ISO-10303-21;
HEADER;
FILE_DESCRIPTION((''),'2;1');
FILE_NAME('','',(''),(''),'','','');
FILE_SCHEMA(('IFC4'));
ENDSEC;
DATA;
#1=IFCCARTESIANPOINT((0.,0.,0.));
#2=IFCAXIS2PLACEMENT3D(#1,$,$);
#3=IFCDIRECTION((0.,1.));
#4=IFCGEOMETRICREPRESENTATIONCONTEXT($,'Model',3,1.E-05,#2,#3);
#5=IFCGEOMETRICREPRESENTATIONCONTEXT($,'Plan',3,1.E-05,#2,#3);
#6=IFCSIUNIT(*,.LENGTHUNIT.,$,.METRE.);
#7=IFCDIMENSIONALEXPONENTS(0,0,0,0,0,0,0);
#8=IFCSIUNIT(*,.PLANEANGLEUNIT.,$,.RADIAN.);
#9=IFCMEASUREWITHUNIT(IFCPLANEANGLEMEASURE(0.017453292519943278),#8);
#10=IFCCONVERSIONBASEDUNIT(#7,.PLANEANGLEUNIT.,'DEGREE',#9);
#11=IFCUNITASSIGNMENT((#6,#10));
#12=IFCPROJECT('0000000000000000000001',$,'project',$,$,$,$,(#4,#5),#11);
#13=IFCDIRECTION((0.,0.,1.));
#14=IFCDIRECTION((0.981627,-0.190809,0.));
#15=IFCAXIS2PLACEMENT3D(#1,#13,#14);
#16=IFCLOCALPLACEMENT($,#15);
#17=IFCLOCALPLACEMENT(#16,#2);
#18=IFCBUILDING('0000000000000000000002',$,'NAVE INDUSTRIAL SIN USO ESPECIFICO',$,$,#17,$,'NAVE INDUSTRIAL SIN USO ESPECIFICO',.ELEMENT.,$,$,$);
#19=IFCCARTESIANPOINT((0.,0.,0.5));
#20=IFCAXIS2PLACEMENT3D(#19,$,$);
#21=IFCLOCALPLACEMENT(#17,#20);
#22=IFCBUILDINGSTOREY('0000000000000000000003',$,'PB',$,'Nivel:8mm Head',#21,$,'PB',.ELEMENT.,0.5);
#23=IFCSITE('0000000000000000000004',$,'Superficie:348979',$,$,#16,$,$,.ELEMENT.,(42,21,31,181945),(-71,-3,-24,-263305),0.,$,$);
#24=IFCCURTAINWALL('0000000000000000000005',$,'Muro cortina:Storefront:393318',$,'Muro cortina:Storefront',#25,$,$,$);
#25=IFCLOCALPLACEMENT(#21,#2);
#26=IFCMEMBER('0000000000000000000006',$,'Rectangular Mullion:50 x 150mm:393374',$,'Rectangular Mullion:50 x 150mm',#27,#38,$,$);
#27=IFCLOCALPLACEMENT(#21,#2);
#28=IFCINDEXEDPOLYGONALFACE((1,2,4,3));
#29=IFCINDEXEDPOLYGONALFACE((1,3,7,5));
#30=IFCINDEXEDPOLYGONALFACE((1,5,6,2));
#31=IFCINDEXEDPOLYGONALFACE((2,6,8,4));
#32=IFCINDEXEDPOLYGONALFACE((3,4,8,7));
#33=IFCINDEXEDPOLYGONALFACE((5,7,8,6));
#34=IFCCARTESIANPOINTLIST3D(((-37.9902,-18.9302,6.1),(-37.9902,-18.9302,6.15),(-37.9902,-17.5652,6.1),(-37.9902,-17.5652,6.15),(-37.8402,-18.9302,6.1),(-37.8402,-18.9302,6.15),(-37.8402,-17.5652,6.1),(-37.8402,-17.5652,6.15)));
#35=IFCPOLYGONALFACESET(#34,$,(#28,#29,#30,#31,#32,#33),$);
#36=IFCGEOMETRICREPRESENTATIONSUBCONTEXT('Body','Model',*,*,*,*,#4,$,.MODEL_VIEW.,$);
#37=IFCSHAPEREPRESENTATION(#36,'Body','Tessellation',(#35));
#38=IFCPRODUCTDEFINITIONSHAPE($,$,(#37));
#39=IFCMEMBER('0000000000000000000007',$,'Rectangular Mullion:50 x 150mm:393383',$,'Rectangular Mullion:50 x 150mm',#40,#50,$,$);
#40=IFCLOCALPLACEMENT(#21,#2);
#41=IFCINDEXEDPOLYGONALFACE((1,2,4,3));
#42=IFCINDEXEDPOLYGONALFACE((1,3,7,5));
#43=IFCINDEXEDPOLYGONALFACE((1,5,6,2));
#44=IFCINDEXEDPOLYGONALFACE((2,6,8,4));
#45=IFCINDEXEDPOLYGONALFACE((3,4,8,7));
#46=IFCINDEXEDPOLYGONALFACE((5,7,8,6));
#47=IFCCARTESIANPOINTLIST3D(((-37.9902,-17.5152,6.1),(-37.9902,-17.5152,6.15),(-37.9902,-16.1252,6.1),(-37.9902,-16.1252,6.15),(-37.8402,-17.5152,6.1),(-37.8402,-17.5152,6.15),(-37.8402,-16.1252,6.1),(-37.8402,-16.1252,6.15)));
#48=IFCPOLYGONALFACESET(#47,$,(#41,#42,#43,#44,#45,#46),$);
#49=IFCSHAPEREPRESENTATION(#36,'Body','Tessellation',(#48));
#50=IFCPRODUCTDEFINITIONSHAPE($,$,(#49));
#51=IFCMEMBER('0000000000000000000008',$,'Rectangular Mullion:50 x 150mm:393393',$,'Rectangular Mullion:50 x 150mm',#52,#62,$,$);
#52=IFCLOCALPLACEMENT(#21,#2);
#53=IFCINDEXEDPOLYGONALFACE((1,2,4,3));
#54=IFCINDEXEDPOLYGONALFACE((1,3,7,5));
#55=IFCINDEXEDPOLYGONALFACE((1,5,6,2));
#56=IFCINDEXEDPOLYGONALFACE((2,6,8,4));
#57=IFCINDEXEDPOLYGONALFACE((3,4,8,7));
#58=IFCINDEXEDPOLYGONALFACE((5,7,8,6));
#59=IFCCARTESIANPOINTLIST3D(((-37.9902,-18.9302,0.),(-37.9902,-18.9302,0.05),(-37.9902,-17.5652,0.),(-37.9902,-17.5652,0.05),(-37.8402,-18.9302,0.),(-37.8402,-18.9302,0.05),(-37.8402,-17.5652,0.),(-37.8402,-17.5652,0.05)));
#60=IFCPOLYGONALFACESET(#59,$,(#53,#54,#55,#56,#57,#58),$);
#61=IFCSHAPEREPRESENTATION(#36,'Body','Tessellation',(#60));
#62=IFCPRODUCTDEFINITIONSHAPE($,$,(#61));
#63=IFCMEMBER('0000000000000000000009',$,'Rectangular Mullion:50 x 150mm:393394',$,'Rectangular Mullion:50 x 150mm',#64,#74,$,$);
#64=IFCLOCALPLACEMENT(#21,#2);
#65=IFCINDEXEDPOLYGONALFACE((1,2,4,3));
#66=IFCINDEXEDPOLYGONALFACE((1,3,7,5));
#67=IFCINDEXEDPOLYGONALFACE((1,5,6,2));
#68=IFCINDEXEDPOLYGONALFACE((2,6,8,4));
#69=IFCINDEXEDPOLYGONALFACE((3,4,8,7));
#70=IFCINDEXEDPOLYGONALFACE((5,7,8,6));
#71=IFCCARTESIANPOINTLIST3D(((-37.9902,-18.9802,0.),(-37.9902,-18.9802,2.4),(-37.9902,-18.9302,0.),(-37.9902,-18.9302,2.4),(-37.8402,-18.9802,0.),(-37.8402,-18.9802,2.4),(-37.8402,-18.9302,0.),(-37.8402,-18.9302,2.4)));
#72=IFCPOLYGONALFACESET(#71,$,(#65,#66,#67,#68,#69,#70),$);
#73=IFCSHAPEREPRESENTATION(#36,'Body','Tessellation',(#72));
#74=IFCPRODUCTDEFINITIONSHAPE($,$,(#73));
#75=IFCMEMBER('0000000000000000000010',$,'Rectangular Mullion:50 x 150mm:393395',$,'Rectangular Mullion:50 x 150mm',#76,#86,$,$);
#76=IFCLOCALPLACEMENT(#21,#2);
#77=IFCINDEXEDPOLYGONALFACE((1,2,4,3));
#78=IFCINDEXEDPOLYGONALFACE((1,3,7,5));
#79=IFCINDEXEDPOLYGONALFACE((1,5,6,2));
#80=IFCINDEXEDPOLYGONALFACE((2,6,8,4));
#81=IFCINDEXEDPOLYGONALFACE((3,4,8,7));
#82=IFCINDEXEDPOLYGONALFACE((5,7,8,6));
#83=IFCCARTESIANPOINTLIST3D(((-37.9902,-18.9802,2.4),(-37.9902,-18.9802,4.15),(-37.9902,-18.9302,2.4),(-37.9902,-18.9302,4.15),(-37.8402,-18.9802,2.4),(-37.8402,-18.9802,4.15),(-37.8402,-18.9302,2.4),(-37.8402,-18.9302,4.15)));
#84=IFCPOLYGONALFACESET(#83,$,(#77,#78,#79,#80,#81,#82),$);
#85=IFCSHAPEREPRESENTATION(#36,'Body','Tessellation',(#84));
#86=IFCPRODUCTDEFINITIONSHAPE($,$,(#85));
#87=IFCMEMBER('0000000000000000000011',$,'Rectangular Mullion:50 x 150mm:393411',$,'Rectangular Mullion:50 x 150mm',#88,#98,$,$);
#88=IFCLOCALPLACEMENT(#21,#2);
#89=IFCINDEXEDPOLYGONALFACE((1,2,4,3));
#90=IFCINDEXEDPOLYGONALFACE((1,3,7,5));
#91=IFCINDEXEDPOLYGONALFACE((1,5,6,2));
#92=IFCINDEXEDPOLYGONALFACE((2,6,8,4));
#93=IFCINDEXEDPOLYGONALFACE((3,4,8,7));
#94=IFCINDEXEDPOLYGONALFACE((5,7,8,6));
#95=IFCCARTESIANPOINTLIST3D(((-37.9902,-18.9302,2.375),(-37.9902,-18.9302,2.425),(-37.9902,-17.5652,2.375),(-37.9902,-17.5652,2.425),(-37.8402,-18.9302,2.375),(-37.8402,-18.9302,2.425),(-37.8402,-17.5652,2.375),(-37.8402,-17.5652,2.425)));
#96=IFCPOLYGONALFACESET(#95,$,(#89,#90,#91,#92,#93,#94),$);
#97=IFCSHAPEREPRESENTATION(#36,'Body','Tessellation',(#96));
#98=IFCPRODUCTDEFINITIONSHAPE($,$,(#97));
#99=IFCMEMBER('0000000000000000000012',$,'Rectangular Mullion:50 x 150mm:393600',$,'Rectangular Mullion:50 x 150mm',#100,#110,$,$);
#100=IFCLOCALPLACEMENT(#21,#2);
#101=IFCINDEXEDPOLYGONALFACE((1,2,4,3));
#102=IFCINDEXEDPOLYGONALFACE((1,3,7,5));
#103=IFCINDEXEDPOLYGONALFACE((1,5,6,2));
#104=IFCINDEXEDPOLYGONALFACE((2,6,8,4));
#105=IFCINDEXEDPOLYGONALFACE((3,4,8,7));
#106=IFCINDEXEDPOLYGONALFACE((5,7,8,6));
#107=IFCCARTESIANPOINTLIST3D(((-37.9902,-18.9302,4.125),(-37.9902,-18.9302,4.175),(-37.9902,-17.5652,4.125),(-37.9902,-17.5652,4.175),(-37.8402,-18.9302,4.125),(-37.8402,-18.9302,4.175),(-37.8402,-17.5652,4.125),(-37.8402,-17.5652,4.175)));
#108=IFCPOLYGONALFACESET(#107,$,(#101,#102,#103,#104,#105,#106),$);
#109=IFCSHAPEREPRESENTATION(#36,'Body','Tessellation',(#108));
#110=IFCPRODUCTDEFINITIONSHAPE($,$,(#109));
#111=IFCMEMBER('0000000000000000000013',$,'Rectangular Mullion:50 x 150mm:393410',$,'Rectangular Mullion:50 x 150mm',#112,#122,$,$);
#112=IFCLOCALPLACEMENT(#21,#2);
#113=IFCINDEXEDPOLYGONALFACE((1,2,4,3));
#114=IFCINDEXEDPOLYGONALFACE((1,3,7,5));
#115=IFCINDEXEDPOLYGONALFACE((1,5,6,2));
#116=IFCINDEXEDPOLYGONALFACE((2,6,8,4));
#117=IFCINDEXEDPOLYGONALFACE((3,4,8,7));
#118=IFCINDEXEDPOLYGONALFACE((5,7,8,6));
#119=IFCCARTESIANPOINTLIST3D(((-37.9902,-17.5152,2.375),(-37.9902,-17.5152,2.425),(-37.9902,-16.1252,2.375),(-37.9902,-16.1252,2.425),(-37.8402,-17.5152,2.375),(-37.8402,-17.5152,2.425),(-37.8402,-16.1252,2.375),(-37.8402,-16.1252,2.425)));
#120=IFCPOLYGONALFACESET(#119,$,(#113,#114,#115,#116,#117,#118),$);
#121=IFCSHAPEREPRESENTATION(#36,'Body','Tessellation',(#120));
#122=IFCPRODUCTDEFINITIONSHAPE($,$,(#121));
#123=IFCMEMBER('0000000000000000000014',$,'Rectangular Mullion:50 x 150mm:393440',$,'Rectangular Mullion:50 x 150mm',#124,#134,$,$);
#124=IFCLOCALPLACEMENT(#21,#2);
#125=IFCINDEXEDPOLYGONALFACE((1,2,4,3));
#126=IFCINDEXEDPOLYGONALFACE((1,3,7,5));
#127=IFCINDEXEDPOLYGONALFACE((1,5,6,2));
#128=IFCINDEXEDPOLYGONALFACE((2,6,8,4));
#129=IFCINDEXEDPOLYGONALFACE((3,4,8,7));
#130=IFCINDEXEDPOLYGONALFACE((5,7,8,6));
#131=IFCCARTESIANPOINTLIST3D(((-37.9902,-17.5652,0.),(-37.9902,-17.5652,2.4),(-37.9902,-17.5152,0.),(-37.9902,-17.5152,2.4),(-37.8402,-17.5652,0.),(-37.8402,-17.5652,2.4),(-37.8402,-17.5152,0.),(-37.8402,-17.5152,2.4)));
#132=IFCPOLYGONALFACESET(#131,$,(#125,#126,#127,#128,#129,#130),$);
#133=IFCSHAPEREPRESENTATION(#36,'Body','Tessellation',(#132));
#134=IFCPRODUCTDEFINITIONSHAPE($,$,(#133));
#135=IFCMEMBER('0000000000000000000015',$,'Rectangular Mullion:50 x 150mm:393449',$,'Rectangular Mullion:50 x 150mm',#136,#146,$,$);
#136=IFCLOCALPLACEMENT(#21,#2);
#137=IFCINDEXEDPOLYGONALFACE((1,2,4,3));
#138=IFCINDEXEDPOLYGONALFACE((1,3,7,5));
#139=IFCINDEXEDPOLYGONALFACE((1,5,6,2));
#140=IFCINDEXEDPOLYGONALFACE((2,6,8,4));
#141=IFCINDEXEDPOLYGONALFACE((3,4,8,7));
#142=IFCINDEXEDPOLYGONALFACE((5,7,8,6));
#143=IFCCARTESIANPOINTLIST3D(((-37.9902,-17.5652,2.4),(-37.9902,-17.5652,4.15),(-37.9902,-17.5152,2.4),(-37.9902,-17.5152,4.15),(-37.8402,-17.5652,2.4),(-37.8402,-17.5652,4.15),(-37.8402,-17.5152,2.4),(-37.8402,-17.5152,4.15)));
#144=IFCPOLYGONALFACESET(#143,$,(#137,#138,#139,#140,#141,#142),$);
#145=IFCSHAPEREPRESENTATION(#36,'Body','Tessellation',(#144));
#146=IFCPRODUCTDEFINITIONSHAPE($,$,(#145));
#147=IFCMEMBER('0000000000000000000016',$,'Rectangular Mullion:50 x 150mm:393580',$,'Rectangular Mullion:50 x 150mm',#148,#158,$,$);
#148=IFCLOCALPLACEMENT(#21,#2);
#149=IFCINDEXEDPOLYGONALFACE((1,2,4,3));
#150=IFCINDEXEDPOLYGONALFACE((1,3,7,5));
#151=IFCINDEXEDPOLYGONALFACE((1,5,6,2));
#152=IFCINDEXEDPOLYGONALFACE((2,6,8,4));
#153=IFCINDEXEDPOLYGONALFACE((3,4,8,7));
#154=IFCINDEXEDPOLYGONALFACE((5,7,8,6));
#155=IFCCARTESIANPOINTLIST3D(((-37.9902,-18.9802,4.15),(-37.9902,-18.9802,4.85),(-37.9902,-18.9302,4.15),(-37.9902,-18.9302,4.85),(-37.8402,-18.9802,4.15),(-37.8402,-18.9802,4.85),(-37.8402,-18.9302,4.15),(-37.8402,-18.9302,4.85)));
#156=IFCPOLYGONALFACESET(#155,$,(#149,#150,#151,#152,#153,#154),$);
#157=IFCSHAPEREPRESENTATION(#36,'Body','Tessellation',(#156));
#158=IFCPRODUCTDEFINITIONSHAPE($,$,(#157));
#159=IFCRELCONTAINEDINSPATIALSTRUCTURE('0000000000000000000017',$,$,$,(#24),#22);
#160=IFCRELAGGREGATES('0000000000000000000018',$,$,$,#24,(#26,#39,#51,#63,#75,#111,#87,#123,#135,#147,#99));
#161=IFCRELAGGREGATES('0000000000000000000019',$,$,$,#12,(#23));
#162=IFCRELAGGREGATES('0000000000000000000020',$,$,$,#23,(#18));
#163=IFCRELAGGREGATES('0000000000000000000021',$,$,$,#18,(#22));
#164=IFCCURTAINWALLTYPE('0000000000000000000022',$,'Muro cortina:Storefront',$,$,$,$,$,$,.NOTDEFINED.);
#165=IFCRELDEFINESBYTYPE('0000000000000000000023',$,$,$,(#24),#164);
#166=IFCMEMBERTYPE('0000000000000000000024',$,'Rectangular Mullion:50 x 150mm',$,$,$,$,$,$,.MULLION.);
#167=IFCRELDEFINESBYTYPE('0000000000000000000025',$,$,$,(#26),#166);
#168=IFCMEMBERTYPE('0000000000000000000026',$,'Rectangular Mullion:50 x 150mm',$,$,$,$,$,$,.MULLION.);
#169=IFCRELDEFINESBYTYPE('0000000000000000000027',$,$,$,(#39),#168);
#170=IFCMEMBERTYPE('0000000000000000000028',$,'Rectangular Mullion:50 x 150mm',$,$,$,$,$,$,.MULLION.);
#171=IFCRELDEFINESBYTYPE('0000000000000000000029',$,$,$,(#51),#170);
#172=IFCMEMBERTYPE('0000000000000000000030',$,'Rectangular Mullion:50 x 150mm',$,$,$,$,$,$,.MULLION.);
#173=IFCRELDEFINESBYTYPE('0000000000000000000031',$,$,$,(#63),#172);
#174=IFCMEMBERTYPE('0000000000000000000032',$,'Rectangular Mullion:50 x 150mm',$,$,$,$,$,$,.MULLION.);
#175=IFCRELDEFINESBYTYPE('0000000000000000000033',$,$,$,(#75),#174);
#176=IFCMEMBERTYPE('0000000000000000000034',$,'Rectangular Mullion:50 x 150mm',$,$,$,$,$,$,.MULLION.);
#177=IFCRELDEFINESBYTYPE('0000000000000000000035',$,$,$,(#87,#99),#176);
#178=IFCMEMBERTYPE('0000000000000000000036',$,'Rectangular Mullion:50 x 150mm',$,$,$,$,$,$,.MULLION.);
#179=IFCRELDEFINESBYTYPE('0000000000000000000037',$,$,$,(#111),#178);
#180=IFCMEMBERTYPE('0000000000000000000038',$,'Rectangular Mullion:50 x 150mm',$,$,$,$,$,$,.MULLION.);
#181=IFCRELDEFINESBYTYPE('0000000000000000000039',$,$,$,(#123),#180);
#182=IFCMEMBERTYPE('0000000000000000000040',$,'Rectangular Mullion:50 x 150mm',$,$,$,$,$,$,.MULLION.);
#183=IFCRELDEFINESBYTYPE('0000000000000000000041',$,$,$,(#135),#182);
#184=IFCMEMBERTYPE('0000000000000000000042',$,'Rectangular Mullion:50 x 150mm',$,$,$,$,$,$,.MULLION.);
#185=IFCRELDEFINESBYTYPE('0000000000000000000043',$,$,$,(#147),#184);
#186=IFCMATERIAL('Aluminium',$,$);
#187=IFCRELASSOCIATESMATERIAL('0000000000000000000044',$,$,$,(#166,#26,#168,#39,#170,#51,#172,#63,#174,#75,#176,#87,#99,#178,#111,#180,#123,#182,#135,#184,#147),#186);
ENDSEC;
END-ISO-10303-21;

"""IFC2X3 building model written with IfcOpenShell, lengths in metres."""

from ifc_helpers import new_model, entity, si_unit, converted_unit, direction, frame, origin, origin_2d_with_axis, place, context, subcontext, project, spatial, rectangle, extrude, source, transform, mapped, material, type_object, type_shapes, element, aggregate, save


model = new_model("IFC2X3")

# Units and contexts
model_context = context("Model", 3, precision=1e-05, world=origin(), true_north=direction((0.0, 1.0)))
plan_context = context("Plan", 3, precision=1e-05, world=origin(), true_north=direction((0.0, 1.0)))
body_context = subcontext(model_context, "Body", "Model", "MODEL_VIEW")
ifc_project = project(units=[si_unit("LENGTHUNIT", "METRE"), converted_unit("PLANEANGLEUNIT", "DEGREE", entity("IfcPlaneAngleMeasure", 0.017453292519943278), si_unit("PLANEANGLEUNIT", "RADIAN"), dimensions=[0, 0, 0, 0, 0, 0, 0])], contexts=[model_context, plan_context])

# Site, building, storey
site_placement = place(None, frame((0.0, 0.0, 0.0), z_axis=(0.0, 0.0, 1.0), x_axis=(0.981627, -0.190809, 0.0)))
site = spatial("IfcSite", under=ifc_project, at=site_placement, Name="Superficie:348979", CompositionType="ELEMENT", RefLatitude=(42, 21, 31, 181945), RefLongitude=(-71, -3, -24, -263305), RefElevation=0.0)
building_placement = place(site_placement, origin())
building = spatial("IfcBuilding", under=site, at=building_placement, Name="NAVE INDUSTRIAL SIN USO ESPECIFICO", LongName="NAVE INDUSTRIAL SIN USO ESPECIFICO", CompositionType="ELEMENT")
storey_placement = place(building_placement, frame((0.0, 0.0, 0.5)))
storey = spatial("IfcBuildingStorey", under=building, at=storey_placement, Name="PB", ObjectType="Nivel:8mm Head", LongName="PB", CompositionType="ELEMENT", Elevation=0.5)

# Curtain wall, members
curtain_wall_type = type_object("IfcCurtainWallType", Name="Muro cortina:Storefront", PredefinedType="NOTDEFINED")
curtain_wall_placement = place(storey_placement, frame((0.0, 0.0, -0.5)))
curtain_wall = element("IfcCurtainWall", 1, at=curtain_wall_placement, inside=storey, type_object=curtain_wall_type, Name="Muro cortina:Storefront:393318", ObjectType="Muro cortina:Storefront")
ifc_material_1 = material(Name="Aluminium")
member_type_1 = type_object("IfcMemberType", Name="Rectangular Mullion:50 x 150mm", PredefinedType="MULLION", material=ifc_material_1)
shared_shape_1 = source(origin(), body_context, "Body", "SweptSolid", [
    extrude(rectangle(XDim=0.05, YDim=0.15, at=origin_2d_with_axis()), frame((-0.025, 0.0, -1.365), z_axis=(0.0, 0.0, 1.0), x_axis=(-1.0, 0.0, 0.0)), (0.0, 0.0, 1.0), 1.365),
])
type_shapes(member_type_1, [shared_shape_1])
member_1_placement = place(curtain_wall_placement, frame((-37.9152, -18.9302, 6.65), z_axis=(0.0, -1.0, 0.0), x_axis=(0.0, 0.0, 1.0)))
member_1 = element("IfcMember", 2, at=member_1_placement, type_object=member_type_1, material=ifc_material_1, Name="Rectangular Mullion:50 x 150mm:393374", ObjectType="Rectangular Mullion:50 x 150mm", context=body_context, shape_type="MappedRepresentation", body=[
    mapped(shared_shape_1, transform((0.0, 0.0, 0.0), scale=1.0)),
])
member_type_2 = type_object("IfcMemberType", Name="Rectangular Mullion:50 x 150mm", PredefinedType="MULLION", material=ifc_material_1)
shared_shape_2 = source(origin(), body_context, "Body", "SweptSolid", [
    extrude(rectangle(XDim=0.05, YDim=0.15, at=origin_2d_with_axis()), frame((-0.025, 0.0, -1.39), z_axis=(0.0, 0.0, 1.0), x_axis=(-1.0, 0.0, 0.0)), (0.0, 0.0, 1.0), 1.39),
])
type_shapes(member_type_2, [shared_shape_2])
member_2_placement = place(curtain_wall_placement, frame((-37.9152, -17.5152, 6.65), z_axis=(0.0, -1.0, 0.0), x_axis=(0.0, 0.0, 1.0)))
member_2 = element("IfcMember", 3, at=member_2_placement, type_object=member_type_2, material=ifc_material_1, Name="Rectangular Mullion:50 x 150mm:393383", ObjectType="Rectangular Mullion:50 x 150mm", context=body_context, shape_type="MappedRepresentation", body=[
    mapped(shared_shape_2, transform((0.0, 0.0, 0.0), scale=1.0)),
])
member_type_3 = type_object("IfcMemberType", Name="Rectangular Mullion:50 x 150mm", PredefinedType="MULLION", material=ifc_material_1)
shared_shape_3 = source(origin(), body_context, "Body", "SweptSolid", [
    extrude(rectangle(XDim=0.05, YDim=0.15, at=origin_2d_with_axis()), frame((-0.025, 0.0, -1.365), z_axis=(0.0, 0.0, 1.0), x_axis=(-1.0, 0.0, 0.0)), (0.0, 0.0, 1.0), 1.365),
])
type_shapes(member_type_3, [shared_shape_3])
member_3_placement = place(curtain_wall_placement, frame((-37.9152, -17.5652, 0.5), z_axis=(0.0, 1.0, 0.0), x_axis=(0.0, 0.0, -1.0)))
member_3 = element("IfcMember", 4, at=member_3_placement, type_object=member_type_3, material=ifc_material_1, Name="Rectangular Mullion:50 x 150mm:393393", ObjectType="Rectangular Mullion:50 x 150mm", context=body_context, shape_type="MappedRepresentation", body=[
    mapped(shared_shape_3, transform((0.0, 0.0, 0.0), scale=1.0)),
])
member_type_4 = type_object("IfcMemberType", Name="Rectangular Mullion:50 x 150mm", PredefinedType="MULLION", material=ifc_material_1)
shared_shape_4 = source(origin(), body_context, "Body", "SweptSolid", [
    extrude(rectangle(XDim=0.05, YDim=0.15, at=origin_2d_with_axis()), frame((-0.025, 0.0, -2.4), z_axis=(0.0, 0.0, 1.0), x_axis=(-1.0, 0.0, 0.0)), (0.0, 0.0, 1.0), 2.4),
])
type_shapes(member_type_4, [shared_shape_4])
member_4_placement = place(curtain_wall_placement, frame((-37.9152, -18.9802, 0.5), z_axis=(0.0, 0.0, -1.0), x_axis=(0.0, -1.0, 0.0)))
member_4 = element("IfcMember", 5, at=member_4_placement, type_object=member_type_4, material=ifc_material_1, Name="Rectangular Mullion:50 x 150mm:393394", ObjectType="Rectangular Mullion:50 x 150mm", context=body_context, shape_type="MappedRepresentation", body=[
    mapped(shared_shape_4, transform((0.0, 0.0, 0.0), scale=1.0)),
])
member_type_5 = type_object("IfcMemberType", Name="Rectangular Mullion:50 x 150mm", PredefinedType="MULLION", material=ifc_material_1)
shared_shape_5 = source(origin(), body_context, "Body", "SweptSolid", [
    extrude(rectangle(XDim=0.05, YDim=0.15, at=origin_2d_with_axis()), frame((-0.025, 0.0, -1.75), z_axis=(0.0, 0.0, 1.0), x_axis=(-1.0, 0.0, 0.0)), (0.0, 0.0, 1.0), 1.75),
])
type_shapes(member_type_5, [shared_shape_5])
member_5_placement = place(curtain_wall_placement, frame((-37.9152, -18.9802, 2.9), z_axis=(0.0, 0.0, -1.0), x_axis=(0.0, -1.0, 0.0)))
member_5 = element("IfcMember", 6, at=member_5_placement, type_object=member_type_5, material=ifc_material_1, Name="Rectangular Mullion:50 x 150mm:393395", ObjectType="Rectangular Mullion:50 x 150mm", context=body_context, shape_type="MappedRepresentation", body=[
    mapped(shared_shape_5, transform((0.0, 0.0, 0.0), scale=1.0)),
])
member_type_6 = type_object("IfcMemberType", Name="Rectangular Mullion:50 x 150mm", PredefinedType="MULLION", material=ifc_material_1)
shared_shape_6 = source(origin(), body_context, "Body", "SweptSolid", [
    extrude(rectangle(XDim=0.05, YDim=0.15, at=origin_2d_with_axis()), frame((0.0, 0.0, -1.365), z_axis=(0.0, 0.0, 1.0), x_axis=(-1.0, 0.0, 0.0)), (0.0, 0.0, 1.0), 1.365),
])
type_shapes(member_type_6, [shared_shape_6])
member_6_placement = place(curtain_wall_placement, frame((-37.9152, -18.9302, 2.9), z_axis=(0.0, -1.0, 0.0), x_axis=(0.0, 0.0, 1.0)))
member_6 = element("IfcMember", 7, at=member_6_placement, type_object=member_type_6, material=ifc_material_1, Name="Rectangular Mullion:50 x 150mm:393411", ObjectType="Rectangular Mullion:50 x 150mm", context=body_context, shape_type="MappedRepresentation", body=[
    mapped(shared_shape_6, transform((0.0, 0.0, 0.0), scale=1.0)),
])
member_7_placement = place(curtain_wall_placement, frame((-37.9152, -18.9302, 4.65), z_axis=(0.0, -1.0, 0.0), x_axis=(0.0, 0.0, 1.0)))
member_7 = element("IfcMember", 8, at=member_7_placement, type_object=member_type_6, material=ifc_material_1, Name="Rectangular Mullion:50 x 150mm:393600", ObjectType="Rectangular Mullion:50 x 150mm", context=body_context, shape_type="MappedRepresentation", body=[
    mapped(shared_shape_6, transform((0.0, 0.0, 0.0), scale=1.0)),
])
member_type_7 = type_object("IfcMemberType", Name="Rectangular Mullion:50 x 150mm", PredefinedType="MULLION", material=ifc_material_1)
shared_shape_7 = source(origin(), body_context, "Body", "SweptSolid", [
    extrude(rectangle(XDim=0.05, YDim=0.15, at=origin_2d_with_axis()), frame((0.0, 0.0, -1.39), z_axis=(0.0, 0.0, 1.0), x_axis=(-1.0, 0.0, 0.0)), (0.0, 0.0, 1.0), 1.39),
])
type_shapes(member_type_7, [shared_shape_7])
member_8_placement = place(curtain_wall_placement, frame((-37.9152, -17.5152, 2.9), z_axis=(0.0, -1.0, 0.0), x_axis=(0.0, 0.0, 1.0)))
member_8 = element("IfcMember", 9, at=member_8_placement, type_object=member_type_7, material=ifc_material_1, Name="Rectangular Mullion:50 x 150mm:393410", ObjectType="Rectangular Mullion:50 x 150mm", context=body_context, shape_type="MappedRepresentation", body=[
    mapped(shared_shape_7, transform((0.0, 0.0, 0.0), scale=1.0)),
])
member_type_8 = type_object("IfcMemberType", Name="Rectangular Mullion:50 x 150mm", PredefinedType="MULLION", material=ifc_material_1)
shared_shape_8 = source(origin(), body_context, "Body", "SweptSolid", [
    extrude(rectangle(XDim=0.05, YDim=0.15, at=origin_2d_with_axis()), frame((0.0, 0.0, -2.4), z_axis=(0.0, 0.0, 1.0), x_axis=(-1.0, 0.0, 0.0)), (0.0, 0.0, 1.0), 2.4),
])
type_shapes(member_type_8, [shared_shape_8])
member_9_placement = place(curtain_wall_placement, frame((-37.9152, -17.5402, 0.5), z_axis=(0.0, 0.0, -1.0), x_axis=(0.0, -1.0, 0.0)))
member_9 = element("IfcMember", 10, at=member_9_placement, type_object=member_type_8, material=ifc_material_1, Name="Rectangular Mullion:50 x 150mm:393440", ObjectType="Rectangular Mullion:50 x 150mm", context=body_context, shape_type="MappedRepresentation", body=[
    mapped(shared_shape_8, transform((0.0, 0.0, 0.0), scale=1.0)),
])
member_type_9 = type_object("IfcMemberType", Name="Rectangular Mullion:50 x 150mm", PredefinedType="MULLION", material=ifc_material_1)
shared_shape_9 = source(origin(), body_context, "Body", "SweptSolid", [
    extrude(rectangle(XDim=0.05, YDim=0.15, at=origin_2d_with_axis()), frame((0.0, 0.0, -1.75), z_axis=(0.0, 0.0, 1.0), x_axis=(-1.0, 0.0, 0.0)), (0.0, 0.0, 1.0), 1.75),
])
type_shapes(member_type_9, [shared_shape_9])
member_10_placement = place(curtain_wall_placement, frame((-37.9152, -17.5402, 2.9), z_axis=(0.0, 0.0, -1.0), x_axis=(0.0, -1.0, 0.0)))
member_10 = element("IfcMember", 11, at=member_10_placement, type_object=member_type_9, material=ifc_material_1, Name="Rectangular Mullion:50 x 150mm:393449", ObjectType="Rectangular Mullion:50 x 150mm", context=body_context, shape_type="MappedRepresentation", body=[
    mapped(shared_shape_9, transform((0.0, 0.0, 0.0), scale=1.0)),
])
member_type_10 = type_object("IfcMemberType", Name="Rectangular Mullion:50 x 150mm", PredefinedType="MULLION", material=ifc_material_1)
shared_shape_10 = source(origin(), body_context, "Body", "SweptSolid", [
    extrude(rectangle(XDim=0.05, YDim=0.15, at=origin_2d_with_axis()), frame((-0.025, 0.0, -0.7), z_axis=(0.0, 0.0, 1.0), x_axis=(-1.0, 0.0, 0.0)), (0.0, 0.0, 1.0), 0.7),
])
type_shapes(member_type_10, [shared_shape_10])
member_11_placement = place(curtain_wall_placement, frame((-37.9152, -18.9802, 4.65), z_axis=(0.0, 0.0, -1.0), x_axis=(0.0, -1.0, 0.0)))
member_11 = element("IfcMember", 12, at=member_11_placement, type_object=member_type_10, material=ifc_material_1, Name="Rectangular Mullion:50 x 150mm:393580", ObjectType="Rectangular Mullion:50 x 150mm", context=body_context, shape_type="MappedRepresentation", body=[
    mapped(shared_shape_10, transform((0.0, 0.0, 0.0), scale=1.0)),
])
aggregate(curtain_wall, [member_1, member_2, member_3, member_4, member_5, member_8, member_6, member_9, member_10, member_11, member_7])

save(model, "model.ifc")
